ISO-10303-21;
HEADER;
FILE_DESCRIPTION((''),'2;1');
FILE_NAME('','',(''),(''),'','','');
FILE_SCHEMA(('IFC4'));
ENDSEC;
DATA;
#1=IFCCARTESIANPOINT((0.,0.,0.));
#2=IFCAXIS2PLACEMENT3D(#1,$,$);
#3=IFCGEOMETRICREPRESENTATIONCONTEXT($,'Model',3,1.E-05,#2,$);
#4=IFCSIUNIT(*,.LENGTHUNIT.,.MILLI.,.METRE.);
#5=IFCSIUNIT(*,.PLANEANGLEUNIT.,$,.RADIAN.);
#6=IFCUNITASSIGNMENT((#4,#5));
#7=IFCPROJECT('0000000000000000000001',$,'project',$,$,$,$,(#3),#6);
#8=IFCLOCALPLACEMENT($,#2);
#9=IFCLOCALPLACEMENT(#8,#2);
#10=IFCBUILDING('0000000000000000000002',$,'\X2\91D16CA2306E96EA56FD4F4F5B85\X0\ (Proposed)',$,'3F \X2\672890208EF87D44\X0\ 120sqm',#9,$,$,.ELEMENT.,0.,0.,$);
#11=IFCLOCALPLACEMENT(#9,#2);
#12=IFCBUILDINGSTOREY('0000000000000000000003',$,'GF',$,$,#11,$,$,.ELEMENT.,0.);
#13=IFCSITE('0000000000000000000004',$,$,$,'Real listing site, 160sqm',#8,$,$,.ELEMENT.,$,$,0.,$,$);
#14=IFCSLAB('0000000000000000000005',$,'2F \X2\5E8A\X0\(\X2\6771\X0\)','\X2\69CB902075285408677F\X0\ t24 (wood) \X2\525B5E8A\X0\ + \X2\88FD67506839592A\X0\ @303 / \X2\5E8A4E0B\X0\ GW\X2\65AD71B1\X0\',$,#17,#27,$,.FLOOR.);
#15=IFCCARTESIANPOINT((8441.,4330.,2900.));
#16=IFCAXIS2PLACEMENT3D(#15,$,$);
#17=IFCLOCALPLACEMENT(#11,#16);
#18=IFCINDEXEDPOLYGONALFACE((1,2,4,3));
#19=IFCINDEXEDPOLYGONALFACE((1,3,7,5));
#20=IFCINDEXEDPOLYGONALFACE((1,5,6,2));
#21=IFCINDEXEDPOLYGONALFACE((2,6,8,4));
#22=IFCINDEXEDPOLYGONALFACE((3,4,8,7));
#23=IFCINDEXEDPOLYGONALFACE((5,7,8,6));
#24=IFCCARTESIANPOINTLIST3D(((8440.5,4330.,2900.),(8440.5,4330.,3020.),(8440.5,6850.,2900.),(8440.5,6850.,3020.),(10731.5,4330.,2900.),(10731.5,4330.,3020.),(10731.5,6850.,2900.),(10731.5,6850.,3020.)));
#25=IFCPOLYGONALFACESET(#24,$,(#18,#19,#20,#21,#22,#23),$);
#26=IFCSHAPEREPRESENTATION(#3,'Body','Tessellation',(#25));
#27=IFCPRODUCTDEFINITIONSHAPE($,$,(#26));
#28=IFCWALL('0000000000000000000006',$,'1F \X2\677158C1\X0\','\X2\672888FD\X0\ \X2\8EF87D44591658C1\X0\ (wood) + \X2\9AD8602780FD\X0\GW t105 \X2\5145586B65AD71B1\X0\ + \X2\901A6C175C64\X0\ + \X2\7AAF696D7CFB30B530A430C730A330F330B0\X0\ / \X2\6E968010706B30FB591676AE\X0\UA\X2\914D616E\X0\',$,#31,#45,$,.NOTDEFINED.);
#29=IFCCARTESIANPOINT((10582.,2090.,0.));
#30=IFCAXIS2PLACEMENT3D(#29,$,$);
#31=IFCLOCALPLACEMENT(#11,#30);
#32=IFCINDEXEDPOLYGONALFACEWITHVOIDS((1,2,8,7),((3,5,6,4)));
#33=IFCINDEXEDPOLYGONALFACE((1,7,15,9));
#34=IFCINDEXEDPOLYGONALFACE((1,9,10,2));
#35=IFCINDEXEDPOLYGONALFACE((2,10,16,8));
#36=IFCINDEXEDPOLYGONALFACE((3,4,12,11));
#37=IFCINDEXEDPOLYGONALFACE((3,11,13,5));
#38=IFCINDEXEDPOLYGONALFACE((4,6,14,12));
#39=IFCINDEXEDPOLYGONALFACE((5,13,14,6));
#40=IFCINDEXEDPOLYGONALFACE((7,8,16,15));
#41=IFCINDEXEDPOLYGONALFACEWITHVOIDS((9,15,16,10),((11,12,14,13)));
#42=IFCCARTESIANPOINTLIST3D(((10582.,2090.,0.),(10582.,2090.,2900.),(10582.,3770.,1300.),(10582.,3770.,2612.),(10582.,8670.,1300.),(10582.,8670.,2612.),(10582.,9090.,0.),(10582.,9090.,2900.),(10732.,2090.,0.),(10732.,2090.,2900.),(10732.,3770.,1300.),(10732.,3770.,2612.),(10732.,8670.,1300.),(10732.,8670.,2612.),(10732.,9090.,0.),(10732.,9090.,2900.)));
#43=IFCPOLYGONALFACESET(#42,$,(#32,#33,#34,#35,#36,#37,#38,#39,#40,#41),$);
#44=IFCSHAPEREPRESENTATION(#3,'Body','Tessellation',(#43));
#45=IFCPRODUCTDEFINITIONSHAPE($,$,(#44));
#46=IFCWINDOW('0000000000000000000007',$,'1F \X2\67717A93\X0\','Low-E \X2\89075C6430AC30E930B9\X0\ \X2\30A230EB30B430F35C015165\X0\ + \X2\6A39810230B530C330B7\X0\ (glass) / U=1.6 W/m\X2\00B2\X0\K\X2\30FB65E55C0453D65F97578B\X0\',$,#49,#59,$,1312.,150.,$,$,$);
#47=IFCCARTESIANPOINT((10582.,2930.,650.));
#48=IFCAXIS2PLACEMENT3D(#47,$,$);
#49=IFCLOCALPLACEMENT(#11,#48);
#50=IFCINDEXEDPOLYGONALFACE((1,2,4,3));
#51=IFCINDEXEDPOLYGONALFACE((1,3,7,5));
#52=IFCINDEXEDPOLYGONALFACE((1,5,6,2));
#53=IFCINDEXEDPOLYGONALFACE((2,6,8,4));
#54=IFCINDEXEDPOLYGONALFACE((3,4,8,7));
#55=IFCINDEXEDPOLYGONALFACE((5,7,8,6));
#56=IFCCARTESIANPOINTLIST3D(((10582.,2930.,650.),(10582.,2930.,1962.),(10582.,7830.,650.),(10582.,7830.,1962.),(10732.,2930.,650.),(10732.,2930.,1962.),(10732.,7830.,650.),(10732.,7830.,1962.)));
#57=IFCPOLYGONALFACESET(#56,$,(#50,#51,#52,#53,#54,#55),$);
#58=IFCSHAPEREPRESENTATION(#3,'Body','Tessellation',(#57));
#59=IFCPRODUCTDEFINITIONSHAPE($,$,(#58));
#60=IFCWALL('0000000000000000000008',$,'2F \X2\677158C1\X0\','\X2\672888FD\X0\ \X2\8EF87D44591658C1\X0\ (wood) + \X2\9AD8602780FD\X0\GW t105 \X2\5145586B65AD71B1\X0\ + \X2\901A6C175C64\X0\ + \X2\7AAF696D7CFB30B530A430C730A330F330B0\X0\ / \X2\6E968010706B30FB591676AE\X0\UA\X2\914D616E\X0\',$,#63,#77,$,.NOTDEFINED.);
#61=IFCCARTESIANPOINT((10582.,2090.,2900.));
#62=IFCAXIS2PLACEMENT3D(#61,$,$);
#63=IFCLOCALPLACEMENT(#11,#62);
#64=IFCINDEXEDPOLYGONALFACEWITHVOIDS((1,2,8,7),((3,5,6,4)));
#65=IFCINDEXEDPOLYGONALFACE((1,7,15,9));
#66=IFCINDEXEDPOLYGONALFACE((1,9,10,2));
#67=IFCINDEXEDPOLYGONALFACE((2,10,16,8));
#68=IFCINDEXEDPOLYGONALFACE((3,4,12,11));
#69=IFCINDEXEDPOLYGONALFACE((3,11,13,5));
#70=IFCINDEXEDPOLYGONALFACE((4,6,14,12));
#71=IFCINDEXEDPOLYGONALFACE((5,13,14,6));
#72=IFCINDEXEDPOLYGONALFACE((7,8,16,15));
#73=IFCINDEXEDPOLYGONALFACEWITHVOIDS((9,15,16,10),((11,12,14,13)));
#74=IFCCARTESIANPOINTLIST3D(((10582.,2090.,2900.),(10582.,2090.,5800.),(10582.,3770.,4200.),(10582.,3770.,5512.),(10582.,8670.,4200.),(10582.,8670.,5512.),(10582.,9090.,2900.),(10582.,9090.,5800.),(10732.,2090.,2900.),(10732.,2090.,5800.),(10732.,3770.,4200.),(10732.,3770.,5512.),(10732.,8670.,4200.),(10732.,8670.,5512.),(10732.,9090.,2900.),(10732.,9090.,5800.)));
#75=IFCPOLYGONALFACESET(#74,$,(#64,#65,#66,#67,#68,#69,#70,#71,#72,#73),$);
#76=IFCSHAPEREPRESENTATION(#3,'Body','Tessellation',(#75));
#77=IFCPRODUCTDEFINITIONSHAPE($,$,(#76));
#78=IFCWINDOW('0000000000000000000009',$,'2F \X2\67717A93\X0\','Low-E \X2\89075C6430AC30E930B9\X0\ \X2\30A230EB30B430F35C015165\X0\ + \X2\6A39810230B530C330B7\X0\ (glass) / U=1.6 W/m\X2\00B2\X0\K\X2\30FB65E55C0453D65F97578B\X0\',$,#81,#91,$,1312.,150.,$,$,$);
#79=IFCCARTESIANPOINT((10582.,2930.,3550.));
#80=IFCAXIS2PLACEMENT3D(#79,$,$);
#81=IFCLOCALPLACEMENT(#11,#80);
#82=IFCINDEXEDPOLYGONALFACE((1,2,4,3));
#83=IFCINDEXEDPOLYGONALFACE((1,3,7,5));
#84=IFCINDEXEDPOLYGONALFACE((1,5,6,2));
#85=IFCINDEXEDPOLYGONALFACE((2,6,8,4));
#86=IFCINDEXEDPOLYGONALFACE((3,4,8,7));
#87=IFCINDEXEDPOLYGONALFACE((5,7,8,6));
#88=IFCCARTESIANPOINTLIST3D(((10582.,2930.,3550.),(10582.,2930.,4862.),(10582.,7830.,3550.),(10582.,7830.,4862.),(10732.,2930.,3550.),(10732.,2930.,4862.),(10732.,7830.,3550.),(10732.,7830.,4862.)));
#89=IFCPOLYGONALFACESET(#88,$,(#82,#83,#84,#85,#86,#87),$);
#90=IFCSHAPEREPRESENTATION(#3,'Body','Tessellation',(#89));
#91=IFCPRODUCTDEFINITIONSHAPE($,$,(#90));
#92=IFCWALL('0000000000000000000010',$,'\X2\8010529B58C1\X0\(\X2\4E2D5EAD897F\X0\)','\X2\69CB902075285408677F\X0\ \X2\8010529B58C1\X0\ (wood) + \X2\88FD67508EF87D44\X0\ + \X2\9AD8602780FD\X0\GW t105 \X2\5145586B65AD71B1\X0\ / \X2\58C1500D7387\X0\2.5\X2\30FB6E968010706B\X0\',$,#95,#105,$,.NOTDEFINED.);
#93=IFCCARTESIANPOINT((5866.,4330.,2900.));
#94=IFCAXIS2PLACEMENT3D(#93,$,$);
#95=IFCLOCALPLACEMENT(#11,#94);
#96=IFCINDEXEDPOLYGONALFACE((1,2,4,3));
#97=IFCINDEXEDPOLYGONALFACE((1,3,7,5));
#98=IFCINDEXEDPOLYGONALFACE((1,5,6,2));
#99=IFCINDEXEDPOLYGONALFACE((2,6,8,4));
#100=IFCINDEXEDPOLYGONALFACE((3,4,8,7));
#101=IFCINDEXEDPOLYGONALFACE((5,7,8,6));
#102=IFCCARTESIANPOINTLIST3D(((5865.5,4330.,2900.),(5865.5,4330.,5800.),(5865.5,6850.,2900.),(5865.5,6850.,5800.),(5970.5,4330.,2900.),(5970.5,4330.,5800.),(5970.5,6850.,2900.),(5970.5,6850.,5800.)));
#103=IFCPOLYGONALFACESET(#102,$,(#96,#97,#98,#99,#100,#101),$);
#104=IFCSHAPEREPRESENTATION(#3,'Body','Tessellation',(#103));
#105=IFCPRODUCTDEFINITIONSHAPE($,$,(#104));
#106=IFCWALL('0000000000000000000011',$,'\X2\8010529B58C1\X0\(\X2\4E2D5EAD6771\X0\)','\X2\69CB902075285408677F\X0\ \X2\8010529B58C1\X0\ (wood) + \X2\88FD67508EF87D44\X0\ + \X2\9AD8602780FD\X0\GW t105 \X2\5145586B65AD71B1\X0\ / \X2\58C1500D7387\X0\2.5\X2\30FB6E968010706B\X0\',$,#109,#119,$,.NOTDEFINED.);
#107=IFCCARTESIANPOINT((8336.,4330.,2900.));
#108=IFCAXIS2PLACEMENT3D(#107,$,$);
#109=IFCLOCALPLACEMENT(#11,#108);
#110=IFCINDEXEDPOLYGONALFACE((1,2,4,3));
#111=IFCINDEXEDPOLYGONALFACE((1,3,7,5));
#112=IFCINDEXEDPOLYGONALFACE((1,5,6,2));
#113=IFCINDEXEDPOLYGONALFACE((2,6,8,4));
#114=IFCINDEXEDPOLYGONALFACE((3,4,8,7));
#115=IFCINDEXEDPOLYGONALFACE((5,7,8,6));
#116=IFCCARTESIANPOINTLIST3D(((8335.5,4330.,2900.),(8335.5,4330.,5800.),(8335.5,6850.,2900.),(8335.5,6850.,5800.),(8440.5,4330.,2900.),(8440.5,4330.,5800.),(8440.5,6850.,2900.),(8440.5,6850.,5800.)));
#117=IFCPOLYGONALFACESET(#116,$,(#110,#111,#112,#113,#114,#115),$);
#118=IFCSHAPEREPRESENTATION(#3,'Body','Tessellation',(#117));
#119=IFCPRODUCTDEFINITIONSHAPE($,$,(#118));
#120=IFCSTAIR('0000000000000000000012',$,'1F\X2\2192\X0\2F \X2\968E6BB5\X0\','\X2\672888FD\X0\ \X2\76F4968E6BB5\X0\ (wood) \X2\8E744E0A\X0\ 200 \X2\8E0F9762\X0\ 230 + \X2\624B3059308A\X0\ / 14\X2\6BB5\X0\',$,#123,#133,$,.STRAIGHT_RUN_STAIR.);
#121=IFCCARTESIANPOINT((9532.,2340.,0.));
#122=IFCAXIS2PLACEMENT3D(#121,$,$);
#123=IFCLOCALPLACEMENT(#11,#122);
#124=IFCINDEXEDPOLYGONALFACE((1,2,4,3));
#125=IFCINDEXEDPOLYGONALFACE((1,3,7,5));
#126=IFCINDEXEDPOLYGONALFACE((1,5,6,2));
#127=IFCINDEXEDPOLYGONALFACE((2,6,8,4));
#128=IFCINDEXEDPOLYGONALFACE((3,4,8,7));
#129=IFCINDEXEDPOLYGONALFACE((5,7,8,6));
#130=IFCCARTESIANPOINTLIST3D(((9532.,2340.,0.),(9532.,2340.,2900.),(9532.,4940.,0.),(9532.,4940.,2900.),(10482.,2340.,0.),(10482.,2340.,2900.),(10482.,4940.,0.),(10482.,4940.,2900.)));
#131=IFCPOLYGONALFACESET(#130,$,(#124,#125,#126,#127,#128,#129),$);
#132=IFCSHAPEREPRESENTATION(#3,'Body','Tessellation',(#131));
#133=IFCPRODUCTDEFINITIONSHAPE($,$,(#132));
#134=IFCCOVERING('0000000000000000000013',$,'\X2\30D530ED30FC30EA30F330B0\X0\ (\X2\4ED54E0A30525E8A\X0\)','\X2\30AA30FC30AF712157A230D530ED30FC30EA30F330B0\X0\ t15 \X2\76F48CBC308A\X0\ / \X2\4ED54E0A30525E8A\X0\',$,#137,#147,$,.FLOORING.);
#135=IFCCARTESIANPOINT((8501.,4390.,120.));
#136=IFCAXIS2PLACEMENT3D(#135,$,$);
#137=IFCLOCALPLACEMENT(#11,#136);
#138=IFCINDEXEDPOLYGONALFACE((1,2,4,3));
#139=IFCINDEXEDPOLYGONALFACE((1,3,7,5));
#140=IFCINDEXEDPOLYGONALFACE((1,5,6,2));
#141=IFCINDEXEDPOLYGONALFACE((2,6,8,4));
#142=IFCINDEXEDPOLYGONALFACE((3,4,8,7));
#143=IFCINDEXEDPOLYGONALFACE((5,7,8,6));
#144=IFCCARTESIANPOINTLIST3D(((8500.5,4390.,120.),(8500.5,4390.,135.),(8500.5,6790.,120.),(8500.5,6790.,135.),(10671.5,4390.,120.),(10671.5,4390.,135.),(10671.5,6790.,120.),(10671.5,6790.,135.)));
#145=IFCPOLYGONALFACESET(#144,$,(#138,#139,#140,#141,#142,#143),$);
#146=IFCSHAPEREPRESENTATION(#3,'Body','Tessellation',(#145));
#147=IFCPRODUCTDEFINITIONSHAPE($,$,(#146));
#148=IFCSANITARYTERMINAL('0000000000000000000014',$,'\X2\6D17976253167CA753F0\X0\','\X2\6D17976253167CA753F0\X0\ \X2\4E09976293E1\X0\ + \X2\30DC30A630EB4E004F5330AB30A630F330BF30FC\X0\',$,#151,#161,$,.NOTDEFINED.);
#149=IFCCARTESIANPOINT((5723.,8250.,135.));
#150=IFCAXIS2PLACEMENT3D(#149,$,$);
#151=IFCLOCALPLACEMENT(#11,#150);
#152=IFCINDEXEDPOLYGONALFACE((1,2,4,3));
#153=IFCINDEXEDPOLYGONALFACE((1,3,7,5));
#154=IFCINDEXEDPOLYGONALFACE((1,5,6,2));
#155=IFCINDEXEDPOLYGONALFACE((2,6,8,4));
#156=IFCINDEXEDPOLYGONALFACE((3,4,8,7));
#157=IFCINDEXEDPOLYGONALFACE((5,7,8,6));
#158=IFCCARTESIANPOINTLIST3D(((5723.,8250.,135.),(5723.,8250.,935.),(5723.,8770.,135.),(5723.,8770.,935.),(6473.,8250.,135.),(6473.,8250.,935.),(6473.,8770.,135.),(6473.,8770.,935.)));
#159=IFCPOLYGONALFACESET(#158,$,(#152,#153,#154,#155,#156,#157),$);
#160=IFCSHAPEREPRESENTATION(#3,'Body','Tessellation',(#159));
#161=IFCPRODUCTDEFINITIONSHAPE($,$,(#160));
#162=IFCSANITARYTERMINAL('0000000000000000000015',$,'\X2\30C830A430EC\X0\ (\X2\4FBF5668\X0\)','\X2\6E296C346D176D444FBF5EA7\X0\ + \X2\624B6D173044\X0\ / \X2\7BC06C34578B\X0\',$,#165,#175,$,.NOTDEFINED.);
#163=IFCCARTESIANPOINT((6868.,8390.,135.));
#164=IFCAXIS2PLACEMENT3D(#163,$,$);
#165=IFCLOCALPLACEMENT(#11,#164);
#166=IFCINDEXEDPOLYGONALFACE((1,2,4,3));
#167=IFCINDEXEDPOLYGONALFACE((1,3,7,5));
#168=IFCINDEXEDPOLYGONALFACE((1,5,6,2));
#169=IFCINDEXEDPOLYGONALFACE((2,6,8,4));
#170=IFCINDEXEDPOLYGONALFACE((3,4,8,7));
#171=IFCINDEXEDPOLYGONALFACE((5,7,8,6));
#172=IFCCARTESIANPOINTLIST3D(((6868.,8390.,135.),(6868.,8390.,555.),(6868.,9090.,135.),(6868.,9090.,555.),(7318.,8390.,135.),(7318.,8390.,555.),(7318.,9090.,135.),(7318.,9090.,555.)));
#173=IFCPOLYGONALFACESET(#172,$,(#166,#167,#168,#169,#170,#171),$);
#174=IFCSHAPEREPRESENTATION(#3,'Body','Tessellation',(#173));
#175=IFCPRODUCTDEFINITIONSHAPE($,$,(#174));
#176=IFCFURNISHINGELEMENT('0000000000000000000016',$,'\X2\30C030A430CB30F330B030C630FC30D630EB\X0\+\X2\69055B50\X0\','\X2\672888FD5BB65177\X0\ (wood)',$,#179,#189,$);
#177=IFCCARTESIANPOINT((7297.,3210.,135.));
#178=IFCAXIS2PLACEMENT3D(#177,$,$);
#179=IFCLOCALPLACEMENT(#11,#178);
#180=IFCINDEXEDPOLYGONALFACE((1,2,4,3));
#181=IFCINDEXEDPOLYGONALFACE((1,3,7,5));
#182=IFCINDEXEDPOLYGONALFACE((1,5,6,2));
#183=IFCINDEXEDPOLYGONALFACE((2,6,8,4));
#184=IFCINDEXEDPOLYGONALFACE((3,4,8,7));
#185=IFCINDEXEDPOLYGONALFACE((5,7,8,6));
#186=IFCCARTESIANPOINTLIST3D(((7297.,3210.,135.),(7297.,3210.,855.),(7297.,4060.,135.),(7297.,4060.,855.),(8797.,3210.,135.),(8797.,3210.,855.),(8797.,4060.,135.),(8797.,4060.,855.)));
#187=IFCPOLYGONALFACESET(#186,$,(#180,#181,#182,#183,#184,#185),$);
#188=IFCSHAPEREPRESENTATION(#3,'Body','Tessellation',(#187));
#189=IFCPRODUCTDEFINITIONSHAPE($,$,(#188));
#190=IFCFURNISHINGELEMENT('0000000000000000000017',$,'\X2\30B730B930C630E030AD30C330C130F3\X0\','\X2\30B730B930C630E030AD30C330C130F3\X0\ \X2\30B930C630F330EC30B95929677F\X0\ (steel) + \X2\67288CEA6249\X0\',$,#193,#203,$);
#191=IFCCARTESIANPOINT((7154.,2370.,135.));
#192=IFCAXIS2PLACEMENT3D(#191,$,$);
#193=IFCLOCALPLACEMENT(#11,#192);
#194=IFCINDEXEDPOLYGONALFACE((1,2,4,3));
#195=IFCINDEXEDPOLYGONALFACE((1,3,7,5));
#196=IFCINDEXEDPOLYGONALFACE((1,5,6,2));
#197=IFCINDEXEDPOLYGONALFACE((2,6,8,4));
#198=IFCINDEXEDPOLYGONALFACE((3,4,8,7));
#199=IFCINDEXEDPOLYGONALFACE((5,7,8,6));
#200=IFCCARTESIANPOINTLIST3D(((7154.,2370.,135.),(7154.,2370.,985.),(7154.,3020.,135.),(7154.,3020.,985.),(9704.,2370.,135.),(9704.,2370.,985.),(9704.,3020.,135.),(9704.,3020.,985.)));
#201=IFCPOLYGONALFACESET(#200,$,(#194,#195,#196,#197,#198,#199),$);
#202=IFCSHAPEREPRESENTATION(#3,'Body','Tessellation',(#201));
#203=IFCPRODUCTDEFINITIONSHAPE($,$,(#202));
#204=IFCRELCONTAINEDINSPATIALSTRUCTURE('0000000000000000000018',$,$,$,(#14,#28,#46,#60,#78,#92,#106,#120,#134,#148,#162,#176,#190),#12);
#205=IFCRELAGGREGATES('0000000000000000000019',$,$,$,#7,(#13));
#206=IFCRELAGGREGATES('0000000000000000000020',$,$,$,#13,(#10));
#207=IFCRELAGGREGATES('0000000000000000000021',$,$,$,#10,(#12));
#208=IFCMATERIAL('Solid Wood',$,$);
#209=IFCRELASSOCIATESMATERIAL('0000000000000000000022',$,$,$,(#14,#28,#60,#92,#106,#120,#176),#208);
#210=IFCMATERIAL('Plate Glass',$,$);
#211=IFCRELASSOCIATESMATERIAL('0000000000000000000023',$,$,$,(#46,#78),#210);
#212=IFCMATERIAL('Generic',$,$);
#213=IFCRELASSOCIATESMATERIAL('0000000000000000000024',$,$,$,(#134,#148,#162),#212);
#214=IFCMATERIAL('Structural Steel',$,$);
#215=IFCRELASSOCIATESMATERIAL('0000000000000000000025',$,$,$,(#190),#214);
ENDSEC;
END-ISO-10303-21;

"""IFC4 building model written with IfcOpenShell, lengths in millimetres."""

from ifc_helpers import new_model, si_unit, frame, frame_2d, origin, place, context, project, spatial, rectangle, extrude, material, element, fill, save


model = new_model("IFC4")

# Units and contexts
model_context = context("Model", 3, precision=1e-05, world=origin())
ifc_project = project(units=[si_unit("LENGTHUNIT", "METRE", prefix="MILLI"), si_unit("PLANEANGLEUNIT", "RADIAN")], contexts=[model_context])

# Site, building, storey
site_placement = place(None, origin())
site = spatial("IfcSite", under=ifc_project, at=site_placement, ObjectType="Real listing site, 160sqm", CompositionType="ELEMENT", RefElevation=0.0)
building_placement = place(site_placement, origin())
building = spatial("IfcBuilding", under=site, at=building_placement, Name="金沢の雪国住宅 (Proposed)", ObjectType="3F 木造軸組 120sqm", CompositionType="ELEMENT", ElevationOfRefHeight=0.0, ElevationOfTerrain=0.0)
storey_placement = place(building_placement, origin())
storey = spatial("IfcBuildingStorey", under=building, at=storey_placement, Name="GF", CompositionType="ELEMENT", Elevation=0.0)

# Slab
ifc_material_1 = material(Name="Solid Wood")
slab_1_placement = place(storey_placement, frame((8441.0, 4330.0, 2900.0)))
element("IfcSlab", 1, at=slab_1_placement, inside=storey, material=ifc_material_1, Name="2F 床(東)", Description="構造用合板 t24 (wood) 剛床 + 製材根太 @303 / 床下 GW断熱", PredefinedType="FLOOR", context=model_context, shape_type="SweptSolid", body=[
    extrude(rectangle(XDim=2291.0, YDim=2520.0, at=frame_2d((1145.0, 1260.0))), frame((8441.0, 4330.0, 2900.0)), (0.0, 0.0, 1.0), 120.0),
])

# Wall, opening, window
wall_1_placement = place(storey_placement, frame((10582.0, 2090.0, 0.0)))
wall_1 = element("IfcWall", 2, at=wall_1_placement, inside=storey, material=ifc_material_1, Name="1F 東壁", Description="木製 軸組外壁 (wood) + 高性能GW t105 充填断熱 + 通気層 + 窯業系サイディング / 準耐火・外皮UA配慮", PredefinedType="NOTDEFINED", context=model_context, shape_type="SweptSolid", body=[
    extrude(rectangle(XDim=150.0, YDim=7000.0, at=frame_2d((75.0, 3500.0))), frame((10582.0, 2090.0, 0.0)), (0.0, 0.0, 1.0), 2900.0),
])
opening_1_placement = place(storey_placement, frame((10582.0, 2930.0, 650.0)))
opening_1 = element("IfcOpeningElement", 3, at=opening_1_placement, cuts=wall_1, PredefinedType="NOTDEFINED", context=model_context, shape_type="SweptSolid", body=[
    extrude(rectangle(XDim=150.0, YDim=4900.0, at=frame_2d((75.0, 2450.0))), frame((10582.0, 2930.0, 650.0)), (0.0, 0.0, 1.0), 1312.0),
])
ifc_material_2 = material(Name="Plate Glass")
window_1_placement = place(storey_placement, frame((10582.0, 2930.0, 650.0)))
window_1 = element("IfcWindow", 4, at=window_1_placement, inside=storey, material=ifc_material_2, Name="1F 東窓", Description="Low-E 複層ガラス アルゴン封入 + 樹脂サッシ (glass) / U=1.6 W/m²K・日射取得型", OverallHeight=1312.0, OverallWidth=150.0, context=model_context, shape_type="SweptSolid", body=[
    extrude(rectangle(XDim=150.0, YDim=4900.0, at=frame_2d((75.0, 2450.0))), frame((10582.0, 2930.0, 650.0)), (0.0, 0.0, 1.0), 1312.0),
])
fill(opening_1, window_1)

# Wall, opening, window
wall_2_placement = place(storey_placement, frame((10582.0, 2090.0, 2900.0)))
wall_2 = element("IfcWall", 5, at=wall_2_placement, inside=storey, material=ifc_material_1, Name="2F 東壁", Description="木製 軸組外壁 (wood) + 高性能GW t105 充填断熱 + 通気層 + 窯業系サイディング / 準耐火・外皮UA配慮", PredefinedType="NOTDEFINED", context=model_context, shape_type="SweptSolid", body=[
    extrude(rectangle(XDim=150.0, YDim=7000.0, at=frame_2d((75.0, 3500.0))), frame((10582.0, 2090.0, 2900.0)), (0.0, 0.0, 1.0), 2900.0),
])
opening_2_placement = place(storey_placement, frame((10582.0, 2930.0, 3550.0)))
opening_2 = element("IfcOpeningElement", 6, at=opening_2_placement, cuts=wall_2, PredefinedType="NOTDEFINED", context=model_context, shape_type="SweptSolid", body=[
    extrude(rectangle(XDim=150.0, YDim=4900.0, at=frame_2d((75.0, 2450.0))), frame((10582.0, 2930.0, 3550.0)), (0.0, 0.0, 1.0), 1312.0),
])
window_2_placement = place(storey_placement, frame((10582.0, 2930.0, 3550.0)))
window_2 = element("IfcWindow", 7, at=window_2_placement, inside=storey, material=ifc_material_2, Name="2F 東窓", Description="Low-E 複層ガラス アルゴン封入 + 樹脂サッシ (glass) / U=1.6 W/m²K・日射取得型", OverallHeight=1312.0, OverallWidth=150.0, context=model_context, shape_type="SweptSolid", body=[
    extrude(rectangle(XDim=150.0, YDim=4900.0, at=frame_2d((75.0, 2450.0))), frame((10582.0, 2930.0, 3550.0)), (0.0, 0.0, 1.0), 1312.0),
])
fill(opening_2, window_2)

# Walls
wall_3_placement = place(storey_placement, frame((5866.0, 4330.0, 2900.0)))
element("IfcWall", 8, at=wall_3_placement, inside=storey, material=ifc_material_1, Name="耐力壁(中庭西)", Description="構造用合板 耐力壁 (wood) + 製材軸組 + 高性能GW t105 充填断熱 / 壁倍率2.5・準耐火", PredefinedType="NOTDEFINED", context=model_context, shape_type="SweptSolid", body=[
    extrude(rectangle(XDim=105.0, YDim=2520.0, at=frame_2d((52.0, 1260.0))), frame((5866.0, 4330.0, 2900.0)), (0.0, 0.0, 1.0), 2900.0),
])
wall_4_placement = place(storey_placement, frame((8336.0, 4330.0, 2900.0)))
element("IfcWall", 9, at=wall_4_placement, inside=storey, material=ifc_material_1, Name="耐力壁(中庭東)", Description="構造用合板 耐力壁 (wood) + 製材軸組 + 高性能GW t105 充填断熱 / 壁倍率2.5・準耐火", PredefinedType="NOTDEFINED", context=model_context, shape_type="SweptSolid", body=[
    extrude(rectangle(XDim=105.0, YDim=2520.0, at=frame_2d((52.0, 1260.0))), frame((8336.0, 4330.0, 2900.0)), (0.0, 0.0, 1.0), 2900.0),
])

# Stair
stair_placement = place(storey_placement, frame((9532.0, 2340.0, 0.0)))
element("IfcStair", 10, at=stair_placement, inside=storey, material=ifc_material_1, Name="1F→2F 階段", Description="木製 直階段 (wood) 蹴上 200 踏面 230 + 手すり / 14段", PredefinedType="STRAIGHT_RUN_STAIR", context=model_context, shape_type="SweptSolid", body=[
    extrude(rectangle(XDim=950.0, YDim=2600.0, at=frame_2d((475.0, 1300.0))), frame((9532.0, 2340.0, 0.0)), (0.0, 0.0, 1.0), 2900.0),
])

# Covering
ifc_material_3 = material(Name="Generic")
covering_placement = place(storey_placement, frame((8501.0, 4390.0, 120.0)))
element("IfcCovering", 11, at=covering_placement, inside=storey, material=ifc_material_3, Name="フローリング (仕上げ床)", Description="オーク無垢フローリング t15 直貼り / 仕上げ床", PredefinedType="FLOORING", context=model_context, shape_type="SweptSolid", body=[
    extrude(rectangle(XDim=2171.0, YDim=2400.0, at=frame_2d((1085.0, 1200.0))), frame((8501.0, 4390.0, 120.0)), (0.0, 0.0, 1.0), 15.0),
])

# Sanitary terminals
sanitary_terminal_1_placement = place(storey_placement, frame((5723.0, 8250.0, 135.0)))
element("IfcSanitaryTerminal", 12, at=sanitary_terminal_1_placement, inside=storey, material=ifc_material_3, Name="洗面化粧台", Description="洗面化粧台 三面鏡 + ボウル一体カウンター", PredefinedType="NOTDEFINED", context=model_context, shape_type="SweptSolid", body=[
    extrude(rectangle(XDim=750.0, YDim=520.0, at=frame_2d((375.0, 260.0))), frame((5723.0, 8250.0, 135.0)), (0.0, 0.0, 1.0), 800.0),
])
sanitary_terminal_2_placement = place(storey_placement, frame((6868.0, 8390.0, 135.0)))
element("IfcSanitaryTerminal", 13, at=sanitary_terminal_2_placement, inside=storey, material=ifc_material_3, Name="トイレ (便器)", Description="温水洗浄便座 + 手洗い / 節水型", PredefinedType="NOTDEFINED", context=model_context, shape_type="SweptSolid", body=[
    extrude(rectangle(XDim=450.0, YDim=700.0, at=frame_2d((225.0, 350.0))), frame((6868.0, 8390.0, 135.0)), (0.0, 0.0, 1.0), 420.0),
])

# Furnishing elements
furnishing_1_placement = place(storey_placement, frame((7297.0, 3210.0, 135.0)))
element("IfcFurnishingElement", 14, at=furnishing_1_placement, inside=storey, material=ifc_material_1, Name="ダイニングテーブル+椅子", Description="木製家具 (wood)", context=model_context, shape_type="SweptSolid", body=[
    extrude(rectangle(XDim=1500.0, YDim=850.0, at=frame_2d((750.0, 425.0))), frame((7297.0, 3210.0, 135.0)), (0.0, 0.0, 1.0), 720.0),
])
ifc_material_4 = material(Name="Structural Steel")
furnishing_2_placement = place(storey_placement, frame((7154.0, 2370.0, 135.0)))
element("IfcFurnishingElement", 15, at=furnishing_2_placement, inside=storey, material=ifc_material_4, Name="システムキッチン", Description="システムキッチン ステンレス天板 (steel) + 木質扉", context=model_context, shape_type="SweptSolid", body=[
    extrude(rectangle(XDim=2550.0, YDim=650.0, at=frame_2d((1275.0, 325.0))), frame((7154.0, 2370.0, 135.0)), (0.0, 0.0, 1.0), 850.0),
])

save(model, "model.ifc")
